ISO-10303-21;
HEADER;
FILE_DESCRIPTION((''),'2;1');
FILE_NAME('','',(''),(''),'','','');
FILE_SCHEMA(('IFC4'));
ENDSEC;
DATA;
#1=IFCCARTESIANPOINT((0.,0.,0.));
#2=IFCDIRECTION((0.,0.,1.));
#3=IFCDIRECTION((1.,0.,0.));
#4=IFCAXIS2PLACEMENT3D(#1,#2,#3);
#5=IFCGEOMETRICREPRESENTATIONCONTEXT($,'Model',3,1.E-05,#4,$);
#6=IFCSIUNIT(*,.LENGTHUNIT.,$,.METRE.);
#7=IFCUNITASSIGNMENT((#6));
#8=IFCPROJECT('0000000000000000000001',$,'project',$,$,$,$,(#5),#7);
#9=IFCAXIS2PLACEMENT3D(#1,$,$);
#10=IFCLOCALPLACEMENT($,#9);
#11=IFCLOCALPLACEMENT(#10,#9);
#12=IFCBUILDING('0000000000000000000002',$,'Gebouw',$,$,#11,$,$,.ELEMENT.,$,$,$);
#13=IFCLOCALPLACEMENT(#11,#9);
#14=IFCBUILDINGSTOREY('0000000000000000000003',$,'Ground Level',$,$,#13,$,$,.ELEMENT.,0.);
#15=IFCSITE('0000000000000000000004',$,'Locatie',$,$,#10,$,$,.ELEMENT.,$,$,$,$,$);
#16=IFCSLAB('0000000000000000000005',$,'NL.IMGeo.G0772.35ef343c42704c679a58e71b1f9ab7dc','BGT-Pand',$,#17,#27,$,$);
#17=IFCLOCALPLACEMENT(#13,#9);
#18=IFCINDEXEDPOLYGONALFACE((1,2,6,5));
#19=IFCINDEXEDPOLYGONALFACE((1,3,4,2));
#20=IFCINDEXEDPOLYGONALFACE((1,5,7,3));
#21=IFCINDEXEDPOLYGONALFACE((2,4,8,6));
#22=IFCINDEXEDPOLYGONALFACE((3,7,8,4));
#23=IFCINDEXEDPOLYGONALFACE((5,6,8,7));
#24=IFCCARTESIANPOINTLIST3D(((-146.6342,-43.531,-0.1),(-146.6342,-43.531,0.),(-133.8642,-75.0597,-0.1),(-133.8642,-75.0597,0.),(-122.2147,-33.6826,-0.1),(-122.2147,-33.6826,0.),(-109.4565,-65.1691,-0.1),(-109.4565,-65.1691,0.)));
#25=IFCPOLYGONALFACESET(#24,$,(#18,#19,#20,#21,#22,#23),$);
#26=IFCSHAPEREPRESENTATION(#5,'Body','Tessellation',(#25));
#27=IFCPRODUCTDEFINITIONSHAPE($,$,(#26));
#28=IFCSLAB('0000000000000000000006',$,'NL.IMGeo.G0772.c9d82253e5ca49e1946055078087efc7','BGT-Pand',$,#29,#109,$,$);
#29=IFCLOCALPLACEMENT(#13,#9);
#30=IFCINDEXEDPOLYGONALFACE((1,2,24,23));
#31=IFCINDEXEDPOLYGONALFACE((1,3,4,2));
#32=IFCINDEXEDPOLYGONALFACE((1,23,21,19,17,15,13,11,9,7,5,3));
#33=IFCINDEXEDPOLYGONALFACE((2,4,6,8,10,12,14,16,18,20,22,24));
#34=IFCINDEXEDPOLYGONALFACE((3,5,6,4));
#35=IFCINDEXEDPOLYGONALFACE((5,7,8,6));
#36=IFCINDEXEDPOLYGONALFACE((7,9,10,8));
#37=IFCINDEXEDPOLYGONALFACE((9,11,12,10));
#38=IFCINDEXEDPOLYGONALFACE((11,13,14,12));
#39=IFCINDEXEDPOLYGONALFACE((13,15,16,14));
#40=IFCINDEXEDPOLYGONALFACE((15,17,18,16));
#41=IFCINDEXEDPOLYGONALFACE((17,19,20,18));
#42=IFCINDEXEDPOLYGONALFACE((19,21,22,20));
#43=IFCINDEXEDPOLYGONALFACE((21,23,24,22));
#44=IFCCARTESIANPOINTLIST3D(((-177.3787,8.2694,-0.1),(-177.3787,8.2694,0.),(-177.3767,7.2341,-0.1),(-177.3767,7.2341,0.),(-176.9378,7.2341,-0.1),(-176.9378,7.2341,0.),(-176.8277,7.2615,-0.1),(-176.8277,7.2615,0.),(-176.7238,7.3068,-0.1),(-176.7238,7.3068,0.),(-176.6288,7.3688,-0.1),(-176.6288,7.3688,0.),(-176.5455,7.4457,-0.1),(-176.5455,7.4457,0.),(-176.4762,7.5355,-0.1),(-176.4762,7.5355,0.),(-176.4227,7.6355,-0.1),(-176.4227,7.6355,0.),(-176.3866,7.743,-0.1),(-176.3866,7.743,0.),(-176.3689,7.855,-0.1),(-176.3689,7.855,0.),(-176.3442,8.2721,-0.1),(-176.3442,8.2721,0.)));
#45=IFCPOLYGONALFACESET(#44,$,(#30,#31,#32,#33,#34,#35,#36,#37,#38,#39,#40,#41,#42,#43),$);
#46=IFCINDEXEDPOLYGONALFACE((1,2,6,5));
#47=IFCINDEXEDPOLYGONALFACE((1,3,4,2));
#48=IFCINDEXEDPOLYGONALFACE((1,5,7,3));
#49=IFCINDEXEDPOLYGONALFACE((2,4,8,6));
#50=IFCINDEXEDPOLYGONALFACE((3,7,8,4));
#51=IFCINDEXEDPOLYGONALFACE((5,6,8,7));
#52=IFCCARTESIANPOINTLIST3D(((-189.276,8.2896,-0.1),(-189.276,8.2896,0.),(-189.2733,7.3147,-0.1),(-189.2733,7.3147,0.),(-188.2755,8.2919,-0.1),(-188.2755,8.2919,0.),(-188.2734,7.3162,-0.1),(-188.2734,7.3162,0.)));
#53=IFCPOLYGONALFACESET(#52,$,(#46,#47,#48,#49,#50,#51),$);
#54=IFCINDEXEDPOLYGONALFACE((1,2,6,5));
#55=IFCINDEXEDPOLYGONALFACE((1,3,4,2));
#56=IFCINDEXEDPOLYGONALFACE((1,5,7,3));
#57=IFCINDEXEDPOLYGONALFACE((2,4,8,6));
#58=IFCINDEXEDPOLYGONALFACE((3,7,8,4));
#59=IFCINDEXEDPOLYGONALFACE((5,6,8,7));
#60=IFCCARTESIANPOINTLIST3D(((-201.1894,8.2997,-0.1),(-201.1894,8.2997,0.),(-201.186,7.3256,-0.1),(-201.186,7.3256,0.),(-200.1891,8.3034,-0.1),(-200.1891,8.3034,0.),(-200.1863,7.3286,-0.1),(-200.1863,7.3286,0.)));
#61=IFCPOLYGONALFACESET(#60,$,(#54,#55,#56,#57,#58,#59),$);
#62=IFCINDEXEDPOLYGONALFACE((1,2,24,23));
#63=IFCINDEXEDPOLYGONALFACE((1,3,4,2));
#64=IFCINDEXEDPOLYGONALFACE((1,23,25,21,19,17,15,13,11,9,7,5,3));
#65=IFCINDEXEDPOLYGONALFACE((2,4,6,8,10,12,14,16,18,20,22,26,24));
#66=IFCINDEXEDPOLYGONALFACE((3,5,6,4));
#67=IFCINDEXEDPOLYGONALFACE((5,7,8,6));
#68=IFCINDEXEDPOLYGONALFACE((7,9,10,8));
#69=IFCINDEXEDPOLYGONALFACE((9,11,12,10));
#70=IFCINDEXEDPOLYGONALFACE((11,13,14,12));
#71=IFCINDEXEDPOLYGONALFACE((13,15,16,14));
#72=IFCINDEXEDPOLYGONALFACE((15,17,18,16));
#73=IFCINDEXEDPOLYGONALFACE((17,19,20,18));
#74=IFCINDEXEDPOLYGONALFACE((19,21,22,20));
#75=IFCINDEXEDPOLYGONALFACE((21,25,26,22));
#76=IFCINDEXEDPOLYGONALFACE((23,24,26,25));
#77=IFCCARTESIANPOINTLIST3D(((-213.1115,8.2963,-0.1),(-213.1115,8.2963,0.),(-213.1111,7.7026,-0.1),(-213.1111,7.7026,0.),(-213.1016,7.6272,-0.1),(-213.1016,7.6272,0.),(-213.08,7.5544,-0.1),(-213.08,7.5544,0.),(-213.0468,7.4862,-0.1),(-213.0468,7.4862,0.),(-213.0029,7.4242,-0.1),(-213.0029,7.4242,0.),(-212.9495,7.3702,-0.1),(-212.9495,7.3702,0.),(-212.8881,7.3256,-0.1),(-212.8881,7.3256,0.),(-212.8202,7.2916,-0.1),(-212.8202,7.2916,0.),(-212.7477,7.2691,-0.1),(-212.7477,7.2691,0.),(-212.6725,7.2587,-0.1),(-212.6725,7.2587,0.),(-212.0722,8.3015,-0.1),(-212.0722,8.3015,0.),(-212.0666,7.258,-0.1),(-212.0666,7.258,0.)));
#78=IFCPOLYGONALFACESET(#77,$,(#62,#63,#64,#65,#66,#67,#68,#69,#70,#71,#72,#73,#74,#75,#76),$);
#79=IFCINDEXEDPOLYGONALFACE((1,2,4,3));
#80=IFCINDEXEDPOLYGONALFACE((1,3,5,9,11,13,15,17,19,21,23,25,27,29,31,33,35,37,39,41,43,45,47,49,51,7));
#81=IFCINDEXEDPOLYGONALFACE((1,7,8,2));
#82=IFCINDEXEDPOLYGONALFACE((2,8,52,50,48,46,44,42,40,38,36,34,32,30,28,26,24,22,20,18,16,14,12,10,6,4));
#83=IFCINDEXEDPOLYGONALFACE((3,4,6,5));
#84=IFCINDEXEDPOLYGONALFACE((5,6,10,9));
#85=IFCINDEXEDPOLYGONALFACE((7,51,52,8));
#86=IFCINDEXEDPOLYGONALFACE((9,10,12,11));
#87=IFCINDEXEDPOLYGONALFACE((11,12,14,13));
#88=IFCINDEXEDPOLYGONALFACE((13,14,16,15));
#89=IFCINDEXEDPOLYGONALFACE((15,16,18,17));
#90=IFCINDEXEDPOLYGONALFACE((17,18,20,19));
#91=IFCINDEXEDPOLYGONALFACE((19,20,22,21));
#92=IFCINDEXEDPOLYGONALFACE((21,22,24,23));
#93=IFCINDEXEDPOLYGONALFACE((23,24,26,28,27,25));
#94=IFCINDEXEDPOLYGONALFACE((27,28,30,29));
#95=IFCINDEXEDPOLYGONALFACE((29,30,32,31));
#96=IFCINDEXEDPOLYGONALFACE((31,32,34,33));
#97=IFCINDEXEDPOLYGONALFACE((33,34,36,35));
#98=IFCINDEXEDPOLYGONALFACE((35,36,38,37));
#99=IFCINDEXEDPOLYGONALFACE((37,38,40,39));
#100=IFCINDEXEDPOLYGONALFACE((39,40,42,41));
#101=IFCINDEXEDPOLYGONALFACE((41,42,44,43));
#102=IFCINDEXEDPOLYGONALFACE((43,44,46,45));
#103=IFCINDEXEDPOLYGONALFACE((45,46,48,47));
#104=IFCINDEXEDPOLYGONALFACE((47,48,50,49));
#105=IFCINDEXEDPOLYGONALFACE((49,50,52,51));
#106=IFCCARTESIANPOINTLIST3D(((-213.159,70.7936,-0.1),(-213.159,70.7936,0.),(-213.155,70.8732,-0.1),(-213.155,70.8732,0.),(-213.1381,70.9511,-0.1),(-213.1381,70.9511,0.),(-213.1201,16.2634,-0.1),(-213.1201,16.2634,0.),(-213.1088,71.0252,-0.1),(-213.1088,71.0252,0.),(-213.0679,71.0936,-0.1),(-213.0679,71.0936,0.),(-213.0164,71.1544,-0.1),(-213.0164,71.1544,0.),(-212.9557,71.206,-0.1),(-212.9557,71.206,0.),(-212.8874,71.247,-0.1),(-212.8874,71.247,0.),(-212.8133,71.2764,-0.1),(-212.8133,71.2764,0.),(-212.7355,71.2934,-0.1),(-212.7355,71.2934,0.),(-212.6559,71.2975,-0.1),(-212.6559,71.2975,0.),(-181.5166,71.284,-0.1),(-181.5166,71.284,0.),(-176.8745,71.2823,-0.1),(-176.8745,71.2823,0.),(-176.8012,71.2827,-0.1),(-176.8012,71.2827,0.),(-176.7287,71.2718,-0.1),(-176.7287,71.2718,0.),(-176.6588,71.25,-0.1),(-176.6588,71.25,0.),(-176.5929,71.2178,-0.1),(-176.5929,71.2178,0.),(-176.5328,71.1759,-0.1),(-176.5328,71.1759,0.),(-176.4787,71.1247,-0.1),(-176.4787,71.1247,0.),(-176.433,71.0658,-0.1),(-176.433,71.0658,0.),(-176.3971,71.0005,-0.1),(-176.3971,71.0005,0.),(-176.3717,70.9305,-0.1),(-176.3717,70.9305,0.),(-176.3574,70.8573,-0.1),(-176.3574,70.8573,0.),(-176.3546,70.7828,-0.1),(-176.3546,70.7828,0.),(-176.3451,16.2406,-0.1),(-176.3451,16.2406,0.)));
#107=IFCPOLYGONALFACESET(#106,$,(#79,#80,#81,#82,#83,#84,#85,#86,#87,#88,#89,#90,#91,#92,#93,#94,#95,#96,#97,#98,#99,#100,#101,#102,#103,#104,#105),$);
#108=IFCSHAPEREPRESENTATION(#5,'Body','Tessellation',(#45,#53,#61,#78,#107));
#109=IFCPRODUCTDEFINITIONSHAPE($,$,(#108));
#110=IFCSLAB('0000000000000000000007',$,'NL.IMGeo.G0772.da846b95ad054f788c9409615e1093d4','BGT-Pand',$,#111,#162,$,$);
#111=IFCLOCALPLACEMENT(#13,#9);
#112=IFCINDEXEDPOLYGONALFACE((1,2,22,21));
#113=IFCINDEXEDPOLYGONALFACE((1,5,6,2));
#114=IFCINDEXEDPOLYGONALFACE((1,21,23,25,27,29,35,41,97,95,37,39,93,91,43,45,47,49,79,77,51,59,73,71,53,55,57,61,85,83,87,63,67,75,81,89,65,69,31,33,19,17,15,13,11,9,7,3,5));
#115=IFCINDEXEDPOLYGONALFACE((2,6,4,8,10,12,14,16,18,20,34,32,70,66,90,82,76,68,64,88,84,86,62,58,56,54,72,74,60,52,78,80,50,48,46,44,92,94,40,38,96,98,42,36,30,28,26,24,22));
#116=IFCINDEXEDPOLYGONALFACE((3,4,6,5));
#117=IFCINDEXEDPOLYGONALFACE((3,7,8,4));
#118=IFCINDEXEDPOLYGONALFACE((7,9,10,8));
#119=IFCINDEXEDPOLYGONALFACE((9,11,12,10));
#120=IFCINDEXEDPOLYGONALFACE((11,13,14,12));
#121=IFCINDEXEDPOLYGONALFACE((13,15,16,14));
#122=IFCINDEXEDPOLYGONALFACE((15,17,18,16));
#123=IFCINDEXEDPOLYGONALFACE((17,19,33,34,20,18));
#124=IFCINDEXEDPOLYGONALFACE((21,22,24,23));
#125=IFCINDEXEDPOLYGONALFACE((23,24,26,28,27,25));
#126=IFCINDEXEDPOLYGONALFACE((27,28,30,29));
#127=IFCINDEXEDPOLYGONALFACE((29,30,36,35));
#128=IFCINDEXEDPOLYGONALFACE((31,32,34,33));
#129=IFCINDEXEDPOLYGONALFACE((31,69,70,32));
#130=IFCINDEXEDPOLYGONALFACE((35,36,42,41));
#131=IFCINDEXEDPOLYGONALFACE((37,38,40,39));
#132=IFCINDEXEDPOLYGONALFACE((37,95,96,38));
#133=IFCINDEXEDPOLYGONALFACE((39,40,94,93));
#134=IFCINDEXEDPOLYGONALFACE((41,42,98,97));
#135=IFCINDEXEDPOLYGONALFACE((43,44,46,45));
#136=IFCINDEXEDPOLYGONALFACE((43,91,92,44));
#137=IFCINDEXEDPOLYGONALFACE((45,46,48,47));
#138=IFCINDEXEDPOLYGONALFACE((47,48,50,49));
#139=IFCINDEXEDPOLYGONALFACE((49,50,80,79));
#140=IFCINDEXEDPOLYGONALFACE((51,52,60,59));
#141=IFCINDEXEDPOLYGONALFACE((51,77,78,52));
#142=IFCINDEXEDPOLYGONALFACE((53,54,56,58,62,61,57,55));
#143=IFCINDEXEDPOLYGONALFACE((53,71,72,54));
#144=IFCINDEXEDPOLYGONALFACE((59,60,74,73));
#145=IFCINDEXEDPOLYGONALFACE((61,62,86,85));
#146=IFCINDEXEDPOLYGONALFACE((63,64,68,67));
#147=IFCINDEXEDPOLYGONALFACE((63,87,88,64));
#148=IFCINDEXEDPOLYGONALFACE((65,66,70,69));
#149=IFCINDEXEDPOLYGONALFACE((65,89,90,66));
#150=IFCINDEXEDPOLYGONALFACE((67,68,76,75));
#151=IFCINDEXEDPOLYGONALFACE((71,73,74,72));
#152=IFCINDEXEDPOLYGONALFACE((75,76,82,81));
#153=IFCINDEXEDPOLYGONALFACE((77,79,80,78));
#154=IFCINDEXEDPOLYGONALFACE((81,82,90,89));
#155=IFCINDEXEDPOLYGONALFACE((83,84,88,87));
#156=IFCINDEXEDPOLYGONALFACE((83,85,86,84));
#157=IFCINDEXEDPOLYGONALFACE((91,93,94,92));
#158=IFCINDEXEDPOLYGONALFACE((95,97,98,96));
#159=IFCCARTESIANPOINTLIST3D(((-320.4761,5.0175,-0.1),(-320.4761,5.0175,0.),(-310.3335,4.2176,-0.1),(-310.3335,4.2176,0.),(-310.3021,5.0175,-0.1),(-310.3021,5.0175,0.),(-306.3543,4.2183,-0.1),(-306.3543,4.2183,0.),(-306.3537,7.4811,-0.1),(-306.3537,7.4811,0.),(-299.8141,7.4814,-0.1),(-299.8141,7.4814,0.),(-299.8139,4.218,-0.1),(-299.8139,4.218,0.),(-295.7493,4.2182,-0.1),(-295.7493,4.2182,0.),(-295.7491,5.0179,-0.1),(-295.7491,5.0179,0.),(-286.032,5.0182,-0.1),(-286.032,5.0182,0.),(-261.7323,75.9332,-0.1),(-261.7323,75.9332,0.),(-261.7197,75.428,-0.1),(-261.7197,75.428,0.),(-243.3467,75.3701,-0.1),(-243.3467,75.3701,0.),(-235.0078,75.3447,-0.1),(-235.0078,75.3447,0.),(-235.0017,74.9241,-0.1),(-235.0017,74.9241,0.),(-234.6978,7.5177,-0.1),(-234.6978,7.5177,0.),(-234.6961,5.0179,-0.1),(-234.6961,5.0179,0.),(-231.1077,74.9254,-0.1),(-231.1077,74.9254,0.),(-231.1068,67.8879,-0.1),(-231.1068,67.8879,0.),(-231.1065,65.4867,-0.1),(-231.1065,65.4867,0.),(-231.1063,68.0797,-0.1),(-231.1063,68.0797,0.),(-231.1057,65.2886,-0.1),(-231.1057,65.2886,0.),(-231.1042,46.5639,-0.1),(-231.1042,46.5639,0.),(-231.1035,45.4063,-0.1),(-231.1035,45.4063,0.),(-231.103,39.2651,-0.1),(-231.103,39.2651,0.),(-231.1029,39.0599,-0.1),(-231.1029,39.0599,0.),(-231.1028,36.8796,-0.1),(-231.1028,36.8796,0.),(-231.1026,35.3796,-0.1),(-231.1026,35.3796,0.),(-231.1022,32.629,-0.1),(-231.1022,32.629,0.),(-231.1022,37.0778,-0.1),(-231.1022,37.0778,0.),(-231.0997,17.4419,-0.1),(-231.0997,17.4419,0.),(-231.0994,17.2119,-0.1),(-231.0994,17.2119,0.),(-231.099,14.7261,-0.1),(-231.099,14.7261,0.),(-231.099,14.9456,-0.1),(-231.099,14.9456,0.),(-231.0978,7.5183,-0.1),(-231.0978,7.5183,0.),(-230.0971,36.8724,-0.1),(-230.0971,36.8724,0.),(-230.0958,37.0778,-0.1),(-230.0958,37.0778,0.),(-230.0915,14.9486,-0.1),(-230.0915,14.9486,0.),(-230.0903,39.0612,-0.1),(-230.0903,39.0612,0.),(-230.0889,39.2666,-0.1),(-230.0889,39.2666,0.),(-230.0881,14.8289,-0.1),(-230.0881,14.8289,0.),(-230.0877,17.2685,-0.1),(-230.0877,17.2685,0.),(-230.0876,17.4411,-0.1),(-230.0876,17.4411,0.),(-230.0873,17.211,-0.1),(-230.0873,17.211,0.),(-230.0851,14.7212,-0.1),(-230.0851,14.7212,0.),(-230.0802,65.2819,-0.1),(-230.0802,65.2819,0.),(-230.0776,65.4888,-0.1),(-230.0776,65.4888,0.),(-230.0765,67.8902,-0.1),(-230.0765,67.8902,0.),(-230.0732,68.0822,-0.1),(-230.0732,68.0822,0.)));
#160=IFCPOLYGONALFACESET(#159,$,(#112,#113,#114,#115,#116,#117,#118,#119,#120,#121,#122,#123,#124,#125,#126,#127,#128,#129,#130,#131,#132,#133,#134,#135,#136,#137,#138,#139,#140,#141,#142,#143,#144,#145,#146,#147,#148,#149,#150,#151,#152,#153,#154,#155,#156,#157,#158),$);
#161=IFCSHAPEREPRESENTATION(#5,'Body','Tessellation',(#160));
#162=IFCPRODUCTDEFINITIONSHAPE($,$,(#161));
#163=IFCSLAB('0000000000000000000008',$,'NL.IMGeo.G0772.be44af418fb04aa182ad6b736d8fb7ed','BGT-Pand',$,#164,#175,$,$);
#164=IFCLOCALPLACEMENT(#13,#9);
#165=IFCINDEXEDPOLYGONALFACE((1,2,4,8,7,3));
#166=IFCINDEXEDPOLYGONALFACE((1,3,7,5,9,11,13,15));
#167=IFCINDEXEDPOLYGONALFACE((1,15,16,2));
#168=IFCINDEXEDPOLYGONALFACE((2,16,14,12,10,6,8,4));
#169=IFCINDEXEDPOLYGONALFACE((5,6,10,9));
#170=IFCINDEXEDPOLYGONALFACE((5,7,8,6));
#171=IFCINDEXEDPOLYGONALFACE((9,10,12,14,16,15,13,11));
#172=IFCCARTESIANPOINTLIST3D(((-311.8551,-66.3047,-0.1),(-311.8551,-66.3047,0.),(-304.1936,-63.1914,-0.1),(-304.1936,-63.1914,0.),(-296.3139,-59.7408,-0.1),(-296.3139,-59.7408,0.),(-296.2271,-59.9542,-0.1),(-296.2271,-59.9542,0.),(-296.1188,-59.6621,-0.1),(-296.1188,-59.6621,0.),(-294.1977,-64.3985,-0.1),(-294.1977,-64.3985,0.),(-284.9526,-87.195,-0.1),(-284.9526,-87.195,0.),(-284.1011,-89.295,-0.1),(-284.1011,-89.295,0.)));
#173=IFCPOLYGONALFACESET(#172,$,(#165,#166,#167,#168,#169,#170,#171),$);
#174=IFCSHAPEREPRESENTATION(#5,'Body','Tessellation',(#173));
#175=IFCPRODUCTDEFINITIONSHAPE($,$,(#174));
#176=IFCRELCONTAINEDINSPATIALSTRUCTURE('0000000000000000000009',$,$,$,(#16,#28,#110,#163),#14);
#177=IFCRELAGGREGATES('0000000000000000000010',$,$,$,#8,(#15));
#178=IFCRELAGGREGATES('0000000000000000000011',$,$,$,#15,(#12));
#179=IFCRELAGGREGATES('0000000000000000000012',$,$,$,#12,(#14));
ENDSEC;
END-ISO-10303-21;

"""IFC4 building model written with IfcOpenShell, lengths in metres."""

from ifc_helpers import new_model, si_unit, frame, origin, origin_with_axes, place, context, project, spatial, polyline, outline, extrude, element, save


model = new_model("IFC4")

# Units and contexts
model_context = context("Model", 3, precision=1e-05, world=origin_with_axes())
ifc_project = project(units=[si_unit("LENGTHUNIT", "METRE")], contexts=[model_context])

# Site, building, storey
site_placement = place(None, origin())
site = spatial("IfcSite", under=ifc_project, at=site_placement, Name="Locatie", CompositionType="ELEMENT")
building_placement = place(site_placement, origin())
building = spatial("IfcBuilding", under=site, at=building_placement, Name="Gebouw", CompositionType="ELEMENT")
storey_placement = place(building_placement, origin())
storey = spatial("IfcBuildingStorey", under=building, at=storey_placement, Name="Ground Level", CompositionType="ELEMENT", Elevation=0.0)

# Slabs
slab_1_placement = place(storey_placement, origin())
element("IfcSlab", 1, at=slab_1_placement, inside=storey, Name="NL.IMGeo.G0772.35ef343c42704c679a58e71b1f9ab7dc", Description="BGT-Pand", context=model_context, shape_type="SweptSolid", body=[
    extrude(outline(polyline([(-109.4565, -65.1691), (-133.8642, -75.0597), (-146.6342, -43.531), (-122.2147, -33.6826), (-109.4565, -65.1691)])), frame((0.0, 0.0, -0.1), z_axis=(0.0, 0.0, 1.0), x_axis=(1.0, 0.0, 0.0)), (0.0, 0.0, 1.0), 0.1),
])
slab_2_placement = place(storey_placement, origin())
element("IfcSlab", 2, at=slab_2_placement, inside=storey, Name="NL.IMGeo.G0772.c9d82253e5ca49e1946055078087efc7", Description="BGT-Pand", context=model_context, shape_type="SweptSolid", body=[
    extrude(outline(polyline([(-176.3866, 7.743), (-176.4227, 7.6355), (-176.4762, 7.5355), (-176.5455, 7.4457), (-176.6288, 7.3688), (-176.7238, 7.3068), (-176.8277, 7.2615), (-176.9378, 7.2341), (-177.3767, 7.2341), (-177.3787, 8.2694), (-176.3442, 8.2721), (-176.3689, 7.855), (-176.3866, 7.743)])), frame((0.0, 0.0, -0.1), z_axis=(0.0, 0.0, 1.0), x_axis=(1.0, 0.0, 0.0)), (0.0, 0.0, 1.0), 0.1),
    extrude(outline(polyline([(-188.2755, 8.2919), (-188.2734, 7.3162), (-189.2733, 7.3147), (-189.276, 8.2896), (-188.2755, 8.2919)])), frame((0.0, 0.0, -0.1), z_axis=(0.0, 0.0, 1.0), x_axis=(1.0, 0.0, 0.0)), (0.0, 0.0, 1.0), 0.1),
    extrude(outline(polyline([(-200.1863, 7.3286), (-201.186, 7.3256), (-201.1894, 8.2997), (-200.1891, 8.3034), (-200.1863, 7.3286)])), frame((0.0, 0.0, -0.1), z_axis=(0.0, 0.0, 1.0), x_axis=(1.0, 0.0, 0.0)), (0.0, 0.0, 1.0), 0.1),
    extrude(outline(polyline([(-212.7477, 7.2691), (-212.8202, 7.2916), (-212.8881, 7.3256), (-212.9495, 7.3702), (-213.0029, 7.4242), (-213.0468, 7.4862), (-213.08, 7.5544), (-213.1016, 7.6272), (-213.1111, 7.7026), (-213.1115, 8.2963), (-212.0722, 8.3015), (-212.0666, 7.258), (-212.6725, 7.2587), (-212.7477, 7.2691)])), frame((0.0, 0.0, -0.1), z_axis=(0.0, 0.0, 1.0), x_axis=(1.0, 0.0, 0.0)), (0.0, 0.0, 1.0), 0.1),
    extrude(outline(polyline([(-213.155, 70.8732), (-213.1381, 70.9511), (-213.1088, 71.0252), (-213.0679, 71.0936), (-213.0164, 71.1544), (-212.9557, 71.206), (-212.8874, 71.247), (-212.8133, 71.2764), (-212.7355, 71.2934), (-212.6559, 71.2975), (-181.5166, 71.284), (-176.8745, 71.2823), (-176.8012, 71.2827), (-176.7287, 71.2718), (-176.6588, 71.25), (-176.5929, 71.2178), (-176.5328, 71.1759), (-176.4787, 71.1247), (-176.433, 71.0658), (-176.3971, 71.0005), (-176.3717, 70.9305), (-176.3574, 70.8573), (-176.3546, 70.7828), (-176.3451, 16.2406), (-213.1201, 16.2634), (-213.159, 70.7936), (-213.155, 70.8732)])), frame((0.0, 0.0, -0.1), z_axis=(0.0, 0.0, 1.0), x_axis=(1.0, 0.0, 0.0)), (0.0, 0.0, 1.0), 0.1),
])
slab_3_placement = place(storey_placement, origin())
element("IfcSlab", 3, at=slab_3_placement, inside=storey, Name="NL.IMGeo.G0772.da846b95ad054f788c9409615e1093d4", Description="BGT-Pand", context=model_context, shape_type="SweptSolid", body=[
    extrude(outline(polyline([(-261.7197, 75.428), (-243.3467, 75.3701), (-235.0078, 75.3447), (-235.0017, 74.9241), (-231.1077, 74.9254), (-231.1063, 68.0797), (-230.0732, 68.0822), (-230.0765, 67.8902), (-231.1068, 67.8879), (-231.1065, 65.4867), (-230.0776, 65.4888), (-230.0802, 65.2819), (-231.1057, 65.2886), (-231.1042, 46.5639), (-231.1035, 45.4063), (-231.103, 39.2651), (-230.0889, 39.2666), (-230.0903, 39.0612), (-231.1029, 39.0599), (-231.1022, 37.0778), (-230.0958, 37.0778), (-230.0971, 36.8724), (-231.1028, 36.8796), (-231.1026, 35.3796), (-231.1022, 32.629), (-231.0997, 17.4419), (-230.0876, 17.4411), (-230.0877, 17.2685), (-230.0873, 17.211), (-231.0994, 17.2119), (-231.099, 14.9456), (-230.0915, 14.9486), (-230.0881, 14.8289), (-230.0851, 14.7212), (-231.099, 14.7261), (-231.0978, 7.5183), (-234.6978, 7.5177), (-234.6961, 5.0179), (-286.032, 5.0182), (-295.7491, 5.0179), (-295.7493, 4.2182), (-299.8139, 4.218), (-299.8141, 7.4814), (-306.3537, 7.4811), (-306.3543, 4.2183), (-310.3335, 4.2176), (-310.3021, 5.0175), (-320.4761, 5.0175), (-261.7323, 75.9332), (-261.7197, 75.428)])), frame((0.0, 0.0, -0.1), z_axis=(0.0, 0.0, 1.0), x_axis=(1.0, 0.0, 0.0)), (0.0, 0.0, 1.0), 0.1),
])
slab_4_placement = place(storey_placement, origin())
element("IfcSlab", 4, at=slab_4_placement, inside=storey, Name="NL.IMGeo.G0772.be44af418fb04aa182ad6b736d8fb7ed", Description="BGT-Pand", context=model_context, shape_type="SweptSolid", body=[
    extrude(outline(polyline([(-304.1936, -63.1914), (-296.2271, -59.9542), (-296.3139, -59.7408), (-296.1188, -59.6621), (-294.1977, -64.3985), (-284.9526, -87.195), (-284.1011, -89.295), (-311.8551, -66.3047), (-304.1936, -63.1914)])), frame((0.0, 0.0, -0.1), z_axis=(0.0, 0.0, 1.0), x_axis=(1.0, 0.0, 0.0)), (0.0, 0.0, 1.0), 0.1),
])

save(model, "model.ifc")
